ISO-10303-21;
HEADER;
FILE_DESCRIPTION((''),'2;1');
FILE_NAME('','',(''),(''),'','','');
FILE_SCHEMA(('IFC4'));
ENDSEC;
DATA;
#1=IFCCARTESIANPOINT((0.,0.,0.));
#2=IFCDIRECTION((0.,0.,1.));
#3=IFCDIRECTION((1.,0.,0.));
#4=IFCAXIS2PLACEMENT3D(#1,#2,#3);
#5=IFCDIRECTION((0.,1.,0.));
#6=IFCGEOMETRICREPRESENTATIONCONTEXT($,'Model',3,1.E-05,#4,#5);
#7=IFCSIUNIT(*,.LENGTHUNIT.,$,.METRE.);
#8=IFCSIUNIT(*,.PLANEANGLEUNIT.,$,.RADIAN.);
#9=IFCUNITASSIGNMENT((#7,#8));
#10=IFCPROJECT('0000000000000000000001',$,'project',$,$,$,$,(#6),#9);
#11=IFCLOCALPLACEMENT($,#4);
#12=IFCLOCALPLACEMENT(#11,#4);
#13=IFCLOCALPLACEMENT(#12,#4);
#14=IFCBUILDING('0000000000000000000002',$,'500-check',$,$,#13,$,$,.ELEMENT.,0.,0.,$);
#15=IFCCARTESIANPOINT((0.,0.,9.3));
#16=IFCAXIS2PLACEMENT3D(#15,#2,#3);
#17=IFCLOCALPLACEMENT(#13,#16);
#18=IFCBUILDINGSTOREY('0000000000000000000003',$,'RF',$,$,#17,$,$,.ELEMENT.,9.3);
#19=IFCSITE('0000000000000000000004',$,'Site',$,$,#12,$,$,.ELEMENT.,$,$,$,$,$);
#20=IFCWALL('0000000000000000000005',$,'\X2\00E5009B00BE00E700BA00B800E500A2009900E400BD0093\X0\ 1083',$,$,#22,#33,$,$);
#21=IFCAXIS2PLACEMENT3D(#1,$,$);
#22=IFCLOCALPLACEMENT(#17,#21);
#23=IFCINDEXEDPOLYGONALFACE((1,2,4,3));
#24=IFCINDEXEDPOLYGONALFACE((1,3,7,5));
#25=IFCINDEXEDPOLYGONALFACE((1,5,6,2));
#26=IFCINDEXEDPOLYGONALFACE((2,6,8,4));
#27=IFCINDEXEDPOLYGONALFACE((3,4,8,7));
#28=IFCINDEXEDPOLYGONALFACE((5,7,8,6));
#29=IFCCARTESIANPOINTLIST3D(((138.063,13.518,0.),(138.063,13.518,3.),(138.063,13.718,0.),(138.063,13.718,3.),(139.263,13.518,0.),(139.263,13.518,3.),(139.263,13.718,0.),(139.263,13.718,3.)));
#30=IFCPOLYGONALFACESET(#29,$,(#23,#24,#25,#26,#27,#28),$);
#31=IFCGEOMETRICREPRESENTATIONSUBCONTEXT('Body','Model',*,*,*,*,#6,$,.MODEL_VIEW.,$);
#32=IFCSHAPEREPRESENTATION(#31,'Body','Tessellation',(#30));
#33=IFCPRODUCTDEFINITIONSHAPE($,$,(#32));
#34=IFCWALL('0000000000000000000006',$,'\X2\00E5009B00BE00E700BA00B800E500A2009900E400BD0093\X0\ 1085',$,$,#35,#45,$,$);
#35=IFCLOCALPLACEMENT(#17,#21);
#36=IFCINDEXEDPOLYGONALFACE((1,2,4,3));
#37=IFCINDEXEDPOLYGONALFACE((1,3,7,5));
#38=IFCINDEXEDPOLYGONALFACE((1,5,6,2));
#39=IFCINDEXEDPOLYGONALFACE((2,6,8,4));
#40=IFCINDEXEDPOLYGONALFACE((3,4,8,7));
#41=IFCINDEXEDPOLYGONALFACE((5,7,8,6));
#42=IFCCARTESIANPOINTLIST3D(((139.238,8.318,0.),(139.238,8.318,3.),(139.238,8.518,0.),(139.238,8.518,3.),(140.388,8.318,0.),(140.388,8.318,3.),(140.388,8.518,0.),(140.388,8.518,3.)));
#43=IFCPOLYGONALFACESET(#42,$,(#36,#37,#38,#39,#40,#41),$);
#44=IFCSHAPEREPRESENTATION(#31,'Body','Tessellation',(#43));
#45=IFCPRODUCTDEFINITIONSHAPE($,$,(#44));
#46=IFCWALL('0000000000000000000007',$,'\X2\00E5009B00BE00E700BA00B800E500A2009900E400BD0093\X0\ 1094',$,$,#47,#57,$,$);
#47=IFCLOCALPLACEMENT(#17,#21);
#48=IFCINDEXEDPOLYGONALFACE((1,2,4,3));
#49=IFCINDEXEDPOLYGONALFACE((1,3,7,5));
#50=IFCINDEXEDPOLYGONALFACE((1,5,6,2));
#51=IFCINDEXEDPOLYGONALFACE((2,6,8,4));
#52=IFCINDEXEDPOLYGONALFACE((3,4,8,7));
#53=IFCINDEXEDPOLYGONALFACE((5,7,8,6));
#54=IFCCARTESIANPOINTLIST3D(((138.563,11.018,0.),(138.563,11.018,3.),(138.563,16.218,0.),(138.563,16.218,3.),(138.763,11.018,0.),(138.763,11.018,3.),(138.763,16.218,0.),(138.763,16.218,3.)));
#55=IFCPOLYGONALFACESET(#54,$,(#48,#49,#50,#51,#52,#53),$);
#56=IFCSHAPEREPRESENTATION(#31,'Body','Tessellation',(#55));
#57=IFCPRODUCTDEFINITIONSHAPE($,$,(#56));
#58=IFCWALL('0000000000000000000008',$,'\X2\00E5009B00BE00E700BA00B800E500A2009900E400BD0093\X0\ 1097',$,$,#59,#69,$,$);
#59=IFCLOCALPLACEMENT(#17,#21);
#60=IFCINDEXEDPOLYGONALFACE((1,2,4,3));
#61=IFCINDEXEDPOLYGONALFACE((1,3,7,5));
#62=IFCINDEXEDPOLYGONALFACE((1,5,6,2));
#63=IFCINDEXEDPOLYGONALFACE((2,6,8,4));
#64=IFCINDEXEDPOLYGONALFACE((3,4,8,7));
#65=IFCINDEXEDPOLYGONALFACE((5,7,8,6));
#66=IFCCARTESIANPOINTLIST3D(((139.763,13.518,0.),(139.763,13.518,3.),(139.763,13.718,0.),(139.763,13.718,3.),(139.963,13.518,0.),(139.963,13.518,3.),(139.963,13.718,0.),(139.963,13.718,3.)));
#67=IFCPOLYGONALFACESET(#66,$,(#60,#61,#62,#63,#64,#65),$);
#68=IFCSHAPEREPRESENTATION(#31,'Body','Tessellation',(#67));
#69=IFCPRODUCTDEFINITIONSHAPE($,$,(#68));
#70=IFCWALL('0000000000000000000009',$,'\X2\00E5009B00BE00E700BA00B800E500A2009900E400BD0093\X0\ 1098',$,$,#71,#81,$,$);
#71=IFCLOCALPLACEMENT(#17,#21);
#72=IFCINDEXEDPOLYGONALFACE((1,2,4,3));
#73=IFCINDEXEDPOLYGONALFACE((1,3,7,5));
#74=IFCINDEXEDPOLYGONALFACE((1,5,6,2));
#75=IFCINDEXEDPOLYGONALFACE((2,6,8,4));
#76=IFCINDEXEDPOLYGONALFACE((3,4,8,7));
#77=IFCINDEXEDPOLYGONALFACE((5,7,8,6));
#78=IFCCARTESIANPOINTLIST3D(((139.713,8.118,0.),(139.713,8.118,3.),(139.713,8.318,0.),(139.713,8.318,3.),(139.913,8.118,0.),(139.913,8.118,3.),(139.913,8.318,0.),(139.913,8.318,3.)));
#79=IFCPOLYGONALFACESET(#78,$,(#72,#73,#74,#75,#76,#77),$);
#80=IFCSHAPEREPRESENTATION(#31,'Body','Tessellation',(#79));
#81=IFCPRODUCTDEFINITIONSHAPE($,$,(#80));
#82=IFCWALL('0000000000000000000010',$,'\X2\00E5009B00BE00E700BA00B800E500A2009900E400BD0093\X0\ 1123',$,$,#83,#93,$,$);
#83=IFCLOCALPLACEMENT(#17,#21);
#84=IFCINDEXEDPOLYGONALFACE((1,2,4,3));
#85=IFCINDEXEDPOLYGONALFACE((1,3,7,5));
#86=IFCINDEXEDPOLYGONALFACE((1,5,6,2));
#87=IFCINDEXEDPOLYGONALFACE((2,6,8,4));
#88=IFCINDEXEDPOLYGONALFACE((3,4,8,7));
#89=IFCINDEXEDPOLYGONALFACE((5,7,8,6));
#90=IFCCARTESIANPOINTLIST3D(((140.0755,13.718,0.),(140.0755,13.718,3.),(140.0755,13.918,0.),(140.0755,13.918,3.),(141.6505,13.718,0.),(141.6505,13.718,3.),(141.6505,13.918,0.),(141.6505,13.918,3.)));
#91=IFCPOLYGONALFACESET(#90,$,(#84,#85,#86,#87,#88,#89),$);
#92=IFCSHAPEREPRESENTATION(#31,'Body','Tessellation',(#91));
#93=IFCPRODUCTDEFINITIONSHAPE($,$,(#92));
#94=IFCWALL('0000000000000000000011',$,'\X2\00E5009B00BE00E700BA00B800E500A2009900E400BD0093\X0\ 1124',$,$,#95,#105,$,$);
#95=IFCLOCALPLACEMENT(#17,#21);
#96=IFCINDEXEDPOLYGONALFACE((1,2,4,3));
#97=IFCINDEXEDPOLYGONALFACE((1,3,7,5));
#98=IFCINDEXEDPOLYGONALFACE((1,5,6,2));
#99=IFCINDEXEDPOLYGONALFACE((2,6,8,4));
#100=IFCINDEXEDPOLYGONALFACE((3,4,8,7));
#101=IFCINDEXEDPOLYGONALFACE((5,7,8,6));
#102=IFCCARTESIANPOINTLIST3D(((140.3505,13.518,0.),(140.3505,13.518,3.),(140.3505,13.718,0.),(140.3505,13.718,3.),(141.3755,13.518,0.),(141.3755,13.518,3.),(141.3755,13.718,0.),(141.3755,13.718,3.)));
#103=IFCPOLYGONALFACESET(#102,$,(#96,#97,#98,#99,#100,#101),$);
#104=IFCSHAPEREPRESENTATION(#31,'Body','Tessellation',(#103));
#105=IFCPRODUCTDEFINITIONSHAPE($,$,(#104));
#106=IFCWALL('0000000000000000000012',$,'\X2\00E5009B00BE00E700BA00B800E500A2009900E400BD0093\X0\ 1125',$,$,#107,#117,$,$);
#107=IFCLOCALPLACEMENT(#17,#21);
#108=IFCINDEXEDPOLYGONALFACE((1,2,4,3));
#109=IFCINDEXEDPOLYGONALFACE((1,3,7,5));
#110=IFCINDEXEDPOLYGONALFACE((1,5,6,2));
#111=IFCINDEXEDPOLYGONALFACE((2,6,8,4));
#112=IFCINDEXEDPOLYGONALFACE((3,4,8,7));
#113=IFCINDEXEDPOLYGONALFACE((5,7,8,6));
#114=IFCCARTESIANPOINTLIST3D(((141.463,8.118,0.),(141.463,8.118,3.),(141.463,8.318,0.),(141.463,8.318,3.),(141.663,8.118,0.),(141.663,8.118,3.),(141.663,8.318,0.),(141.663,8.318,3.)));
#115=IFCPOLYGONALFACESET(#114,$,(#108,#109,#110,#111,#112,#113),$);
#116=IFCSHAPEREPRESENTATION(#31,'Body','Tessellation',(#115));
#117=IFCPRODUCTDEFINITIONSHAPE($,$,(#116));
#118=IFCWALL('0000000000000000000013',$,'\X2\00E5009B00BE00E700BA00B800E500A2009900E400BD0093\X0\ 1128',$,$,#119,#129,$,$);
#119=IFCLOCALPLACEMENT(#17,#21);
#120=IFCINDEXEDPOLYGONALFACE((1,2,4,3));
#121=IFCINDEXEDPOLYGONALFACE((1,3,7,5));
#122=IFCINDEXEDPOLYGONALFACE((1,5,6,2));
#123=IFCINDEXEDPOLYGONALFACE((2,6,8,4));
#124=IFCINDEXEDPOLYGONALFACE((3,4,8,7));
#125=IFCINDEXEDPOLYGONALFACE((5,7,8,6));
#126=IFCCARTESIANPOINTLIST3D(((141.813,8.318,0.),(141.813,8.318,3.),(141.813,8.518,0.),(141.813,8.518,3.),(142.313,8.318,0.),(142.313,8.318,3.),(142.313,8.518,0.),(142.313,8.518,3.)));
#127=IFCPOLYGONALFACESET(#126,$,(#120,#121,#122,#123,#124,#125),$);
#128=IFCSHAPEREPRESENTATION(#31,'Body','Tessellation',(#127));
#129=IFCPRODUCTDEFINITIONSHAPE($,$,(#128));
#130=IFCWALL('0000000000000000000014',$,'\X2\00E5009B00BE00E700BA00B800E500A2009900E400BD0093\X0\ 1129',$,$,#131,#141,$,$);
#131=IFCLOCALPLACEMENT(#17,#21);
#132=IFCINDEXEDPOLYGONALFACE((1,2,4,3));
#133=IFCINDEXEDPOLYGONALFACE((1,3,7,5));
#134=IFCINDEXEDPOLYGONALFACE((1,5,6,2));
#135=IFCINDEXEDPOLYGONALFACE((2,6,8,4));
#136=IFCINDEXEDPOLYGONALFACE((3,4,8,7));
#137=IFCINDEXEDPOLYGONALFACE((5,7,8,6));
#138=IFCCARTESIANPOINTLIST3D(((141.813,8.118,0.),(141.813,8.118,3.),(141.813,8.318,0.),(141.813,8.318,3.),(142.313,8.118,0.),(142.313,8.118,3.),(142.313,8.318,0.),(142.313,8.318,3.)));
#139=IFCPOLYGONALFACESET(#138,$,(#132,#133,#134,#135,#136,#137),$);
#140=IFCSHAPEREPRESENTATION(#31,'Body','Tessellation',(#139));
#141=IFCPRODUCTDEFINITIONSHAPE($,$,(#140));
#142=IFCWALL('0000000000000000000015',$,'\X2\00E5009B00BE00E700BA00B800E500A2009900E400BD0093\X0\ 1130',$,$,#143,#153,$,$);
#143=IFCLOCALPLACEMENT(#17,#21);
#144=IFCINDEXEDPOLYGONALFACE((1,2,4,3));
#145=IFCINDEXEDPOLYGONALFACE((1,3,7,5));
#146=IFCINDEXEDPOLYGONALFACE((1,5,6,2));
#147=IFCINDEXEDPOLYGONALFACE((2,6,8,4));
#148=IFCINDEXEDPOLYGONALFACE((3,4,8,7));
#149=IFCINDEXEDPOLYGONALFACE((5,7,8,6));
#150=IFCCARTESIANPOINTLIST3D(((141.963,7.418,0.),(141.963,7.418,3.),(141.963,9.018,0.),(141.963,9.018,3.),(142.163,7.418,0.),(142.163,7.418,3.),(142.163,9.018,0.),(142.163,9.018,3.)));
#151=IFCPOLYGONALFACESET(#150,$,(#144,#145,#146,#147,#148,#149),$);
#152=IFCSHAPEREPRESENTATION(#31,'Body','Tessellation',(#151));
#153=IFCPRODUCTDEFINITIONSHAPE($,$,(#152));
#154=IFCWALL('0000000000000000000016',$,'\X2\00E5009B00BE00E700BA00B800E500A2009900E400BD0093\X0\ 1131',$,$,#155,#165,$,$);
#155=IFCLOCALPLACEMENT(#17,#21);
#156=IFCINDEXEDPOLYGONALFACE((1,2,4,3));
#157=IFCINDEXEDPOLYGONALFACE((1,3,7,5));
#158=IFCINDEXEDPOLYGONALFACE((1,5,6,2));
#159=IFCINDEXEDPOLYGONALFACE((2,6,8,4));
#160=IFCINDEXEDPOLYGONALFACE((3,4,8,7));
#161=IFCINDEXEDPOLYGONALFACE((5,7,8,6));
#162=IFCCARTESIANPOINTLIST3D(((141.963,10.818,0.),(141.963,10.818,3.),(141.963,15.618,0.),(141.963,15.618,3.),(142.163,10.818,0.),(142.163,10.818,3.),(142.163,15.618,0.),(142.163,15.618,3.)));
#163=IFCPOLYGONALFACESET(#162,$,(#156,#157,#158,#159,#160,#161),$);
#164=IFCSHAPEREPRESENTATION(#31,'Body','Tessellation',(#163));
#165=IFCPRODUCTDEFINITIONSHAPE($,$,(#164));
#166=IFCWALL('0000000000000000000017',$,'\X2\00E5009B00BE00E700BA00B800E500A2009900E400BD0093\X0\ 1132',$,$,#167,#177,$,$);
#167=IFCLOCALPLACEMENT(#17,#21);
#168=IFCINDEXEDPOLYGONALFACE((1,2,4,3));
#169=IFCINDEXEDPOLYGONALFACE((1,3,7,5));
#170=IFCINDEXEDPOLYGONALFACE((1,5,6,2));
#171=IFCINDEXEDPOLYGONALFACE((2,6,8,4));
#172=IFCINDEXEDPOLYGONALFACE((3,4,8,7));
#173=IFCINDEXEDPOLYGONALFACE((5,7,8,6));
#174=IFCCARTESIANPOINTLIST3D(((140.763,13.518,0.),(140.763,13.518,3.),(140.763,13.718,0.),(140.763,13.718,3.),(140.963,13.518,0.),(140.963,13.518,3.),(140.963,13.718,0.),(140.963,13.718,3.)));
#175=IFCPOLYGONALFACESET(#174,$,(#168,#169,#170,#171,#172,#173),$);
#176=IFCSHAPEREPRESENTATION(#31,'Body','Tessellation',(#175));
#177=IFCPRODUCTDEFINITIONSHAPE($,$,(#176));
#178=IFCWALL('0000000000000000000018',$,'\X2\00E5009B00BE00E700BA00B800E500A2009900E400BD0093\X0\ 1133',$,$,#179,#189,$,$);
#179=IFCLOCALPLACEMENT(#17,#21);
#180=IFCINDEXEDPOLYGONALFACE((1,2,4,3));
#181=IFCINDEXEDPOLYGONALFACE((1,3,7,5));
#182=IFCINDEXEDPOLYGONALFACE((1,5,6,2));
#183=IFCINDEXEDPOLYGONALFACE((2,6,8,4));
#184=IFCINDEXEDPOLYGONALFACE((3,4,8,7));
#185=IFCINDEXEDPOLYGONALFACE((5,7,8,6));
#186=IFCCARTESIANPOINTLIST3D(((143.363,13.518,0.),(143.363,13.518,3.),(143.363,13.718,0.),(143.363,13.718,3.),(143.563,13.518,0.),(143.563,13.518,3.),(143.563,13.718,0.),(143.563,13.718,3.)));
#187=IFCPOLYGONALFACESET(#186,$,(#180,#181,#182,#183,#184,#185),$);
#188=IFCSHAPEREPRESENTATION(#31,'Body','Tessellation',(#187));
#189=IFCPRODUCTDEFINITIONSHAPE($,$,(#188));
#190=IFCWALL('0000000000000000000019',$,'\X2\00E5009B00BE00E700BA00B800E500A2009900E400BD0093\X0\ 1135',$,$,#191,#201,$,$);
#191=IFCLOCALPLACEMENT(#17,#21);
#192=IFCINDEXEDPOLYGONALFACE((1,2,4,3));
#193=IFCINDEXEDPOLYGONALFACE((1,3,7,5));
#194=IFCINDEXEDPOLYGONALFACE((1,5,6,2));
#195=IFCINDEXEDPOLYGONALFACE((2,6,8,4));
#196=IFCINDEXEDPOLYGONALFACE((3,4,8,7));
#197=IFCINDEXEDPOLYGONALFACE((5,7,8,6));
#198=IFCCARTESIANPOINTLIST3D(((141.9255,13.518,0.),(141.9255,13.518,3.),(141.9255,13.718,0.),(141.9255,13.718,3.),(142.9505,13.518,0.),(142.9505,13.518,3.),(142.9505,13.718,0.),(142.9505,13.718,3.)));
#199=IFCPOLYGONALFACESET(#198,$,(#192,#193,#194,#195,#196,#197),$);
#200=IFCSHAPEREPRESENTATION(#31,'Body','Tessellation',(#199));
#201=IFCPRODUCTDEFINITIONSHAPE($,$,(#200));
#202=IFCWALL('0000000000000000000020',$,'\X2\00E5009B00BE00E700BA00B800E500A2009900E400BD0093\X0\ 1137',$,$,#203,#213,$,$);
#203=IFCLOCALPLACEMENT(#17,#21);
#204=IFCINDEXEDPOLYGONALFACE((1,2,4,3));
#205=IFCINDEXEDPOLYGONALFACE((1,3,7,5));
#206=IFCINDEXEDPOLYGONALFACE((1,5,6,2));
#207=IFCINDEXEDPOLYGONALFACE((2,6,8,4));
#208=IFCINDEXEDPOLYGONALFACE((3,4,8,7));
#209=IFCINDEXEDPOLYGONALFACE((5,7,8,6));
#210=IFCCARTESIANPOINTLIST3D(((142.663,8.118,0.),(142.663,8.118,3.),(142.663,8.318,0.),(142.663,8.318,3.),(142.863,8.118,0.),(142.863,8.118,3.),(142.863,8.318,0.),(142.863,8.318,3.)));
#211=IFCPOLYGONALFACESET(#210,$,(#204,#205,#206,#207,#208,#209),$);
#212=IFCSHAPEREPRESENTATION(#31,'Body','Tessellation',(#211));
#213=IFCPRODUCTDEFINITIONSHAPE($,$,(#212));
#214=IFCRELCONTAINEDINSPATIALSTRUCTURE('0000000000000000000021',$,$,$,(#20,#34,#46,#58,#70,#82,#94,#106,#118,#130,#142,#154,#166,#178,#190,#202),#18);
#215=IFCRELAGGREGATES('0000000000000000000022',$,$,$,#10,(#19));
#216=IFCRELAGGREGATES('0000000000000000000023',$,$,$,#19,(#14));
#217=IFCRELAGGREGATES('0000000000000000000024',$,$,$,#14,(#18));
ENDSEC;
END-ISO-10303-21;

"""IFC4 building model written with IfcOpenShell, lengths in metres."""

from ifc_helpers import new_model, si_unit, direction, frame, frame_2d, origin_with_axes, place, context, subcontext, project, spatial, rectangle, extrude, element, save


model = new_model("IFC4")

# Units and contexts
model_context = context("Model", 3, precision=1e-05, world=origin_with_axes(), true_north=direction((0.0, 1.0, 0.0)))
body_context = subcontext(model_context, "Body", "Model", "MODEL_VIEW")
ifc_project = project(units=[si_unit("LENGTHUNIT", "METRE"), si_unit("PLANEANGLEUNIT", "RADIAN")], contexts=[model_context])

# Site, building, storey
placement = place(None, origin_with_axes())
site_placement = place(placement, origin_with_axes())
site = spatial("IfcSite", under=ifc_project, at=site_placement, Name="Site", CompositionType="ELEMENT")
building_placement = place(site_placement, origin_with_axes())
building = spatial("IfcBuilding", under=site, at=building_placement, Name="500-check", CompositionType="ELEMENT", ElevationOfRefHeight=0.0, ElevationOfTerrain=0.0)
storey_placement = place(building_placement, frame((0.0, 0.0, 9.3), z_axis=(0.0, 0.0, 1.0), x_axis=(1.0, 0.0, 0.0)))
storey = spatial("IfcBuildingStorey", under=building, at=storey_placement, Name="RF", CompositionType="ELEMENT", Elevation=9.3)

# Walls
wall_1_placement = place(storey_placement, frame((138.663, 13.618, 0.0), z_axis=(0.0, 0.0, 1.0), x_axis=(1.0, 0.0, 0.0)))
element("IfcWall", 1, at=wall_1_placement, inside=storey, Name="å\u009b¾çº¸å¢\u0099ä½\u0093 1083", context=body_context, shape_type="SweptSolid", body=[
    extrude(rectangle(XDim=1.2, YDim=0.2, at=frame_2d((0.0, 0.0), x_axis=(1.0, 0.0, 0.0))), frame((0.0, 0.0, 0.0), z_axis=(0.0, 0.0, 1.0)), (0.0, 0.0, 1.0), 3.0),
])
wall_2_placement = place(storey_placement, frame((139.813, 8.418, 0.0), z_axis=(0.0, 0.0, 1.0), x_axis=(-1.0, 0.0, 0.0)))
element("IfcWall", 2, at=wall_2_placement, inside=storey, Name="å\u009b¾çº¸å¢\u0099ä½\u0093 1085", context=body_context, shape_type="SweptSolid", body=[
    extrude(rectangle(XDim=1.15, YDim=0.2, at=frame_2d((0.0, 0.0), x_axis=(1.0, 0.0, 0.0))), frame((0.0, 0.0, 0.0), z_axis=(0.0, 0.0, 1.0)), (0.0, 0.0, 1.0), 3.0),
])
wall_3_placement = place(storey_placement, frame((138.663, 13.618, 0.0), z_axis=(0.0, 0.0, 1.0), x_axis=(0.0, -1.0, 0.0)))
element("IfcWall", 3, at=wall_3_placement, inside=storey, Name="å\u009b¾çº¸å¢\u0099ä½\u0093 1094", context=body_context, shape_type="SweptSolid", body=[
    extrude(rectangle(XDim=5.2, YDim=0.2, at=frame_2d((0.0, 0.0), x_axis=(1.0, 0.0, 0.0))), frame((0.0, 0.0, 0.0), z_axis=(0.0, 0.0, 1.0)), (0.0, 0.0, 1.0), 3.0),
])
for number, where, z_axis, x_axis, name in (
    (4, (139.863, 13.618, 0.0), (0.0, 0.0, 1.0), (0.0, 1.0, 0.0), "å\u009b¾çº¸å¢\u0099ä½\u0093 1097"),
    (5, (139.813, 8.218, 0.0), (0.0, 0.0, 1.0), (0.0, 1.0, 0.0), "å\u009b¾çº¸å¢\u0099ä½\u0093 1098"),
):
    element("IfcWall", number, at=place(storey_placement, frame(where, z_axis=z_axis, x_axis=x_axis)), inside=storey, Name=name, context=body_context, shape_type="SweptSolid", body=[
        extrude(rectangle(XDim=0.2, YDim=0.2, at=frame_2d((0.0, 0.0), x_axis=(1.0, 0.0, 0.0))), frame((0.0, 0.0, 0.0), z_axis=(0.0, 0.0, 1.0)), (0.0, 0.0, 1.0), 3.0),
    ])
wall_4_placement = place(storey_placement, frame((140.863, 13.818, 0.0), z_axis=(0.0, 0.0, 1.0), x_axis=(1.0, 0.0, 0.0)))
element("IfcWall", 6, at=wall_4_placement, inside=storey, Name="å\u009b¾çº¸å¢\u0099ä½\u0093 1123", context=body_context, shape_type="SweptSolid", body=[
    extrude(rectangle(XDim=1.575, YDim=0.2, at=frame_2d((0.0, 0.0), x_axis=(1.0, 0.0, 0.0))), frame((0.0, 0.0, 0.0), z_axis=(0.0, 0.0, 1.0)), (0.0, 0.0, 1.0), 3.0),
])
wall_5_placement = place(storey_placement, frame((140.863, 13.618, 0.0), z_axis=(0.0, 0.0, 1.0), x_axis=(1.0, 0.0, 0.0)))
element("IfcWall", 7, at=wall_5_placement, inside=storey, Name="å\u009b¾çº¸å¢\u0099ä½\u0093 1124", context=body_context, shape_type="SweptSolid", body=[
    extrude(rectangle(XDim=1.025, YDim=0.2, at=frame_2d((0.0, 0.0), x_axis=(1.0, 0.0, 0.0))), frame((0.0, 0.0, 0.0), z_axis=(0.0, 0.0, 1.0)), (0.0, 0.0, 1.0), 3.0),
])
wall_6_placement = place(storey_placement, frame((141.563, 8.218, 0.0), z_axis=(0.0, 0.0, 1.0), x_axis=(0.0, 1.0, 0.0)))
element("IfcWall", 8, at=wall_6_placement, inside=storey, Name="å\u009b¾çº¸å¢\u0099ä½\u0093 1125", context=body_context, shape_type="SweptSolid", body=[
    extrude(rectangle(XDim=0.2, YDim=0.2, at=frame_2d((0.0, 0.0), x_axis=(1.0, 0.0, 0.0))), frame((0.0, 0.0, 0.0), z_axis=(0.0, 0.0, 1.0)), (0.0, 0.0, 1.0), 3.0),
])
for number, where, z_axis, x_axis, name in (
    (9, (142.063, 8.418, 0.0), (0.0, 0.0, 1.0), (-1.0, 0.0, 0.0), "å\u009b¾çº¸å¢\u0099ä½\u0093 1128"),
    (10, (142.063, 8.218, 0.0), (0.0, 0.0, 1.0), (-1.0, 0.0, 0.0), "å\u009b¾çº¸å¢\u0099ä½\u0093 1129"),
):
    element("IfcWall", number, at=place(storey_placement, frame(where, z_axis=z_axis, x_axis=x_axis)), inside=storey, Name=name, context=body_context, shape_type="SweptSolid", body=[
        extrude(rectangle(XDim=0.5, YDim=0.2, at=frame_2d((0.0, 0.0), x_axis=(1.0, 0.0, 0.0))), frame((0.0, 0.0, 0.0), z_axis=(0.0, 0.0, 1.0)), (0.0, 0.0, 1.0), 3.0),
    ])
wall_7_placement = place(storey_placement, frame((142.063, 8.218, 0.0), z_axis=(0.0, 0.0, 1.0), x_axis=(0.0, -1.0, 0.0)))
element("IfcWall", 11, at=wall_7_placement, inside=storey, Name="å\u009b¾çº¸å¢\u0099ä½\u0093 1130", context=body_context, shape_type="SweptSolid", body=[
    extrude(rectangle(XDim=1.6, YDim=0.2, at=frame_2d((0.0, 0.0), x_axis=(1.0, 0.0, 0.0))), frame((0.0, 0.0, 0.0), z_axis=(0.0, 0.0, 1.0)), (0.0, 0.0, 1.0), 3.0),
])
wall_8_placement = place(storey_placement, frame((142.063, 13.218, 0.0), z_axis=(0.0, 0.0, 1.0), x_axis=(0.0, -1.0, 0.0)))
element("IfcWall", 12, at=wall_8_placement, inside=storey, Name="å\u009b¾çº¸å¢\u0099ä½\u0093 1131", context=body_context, shape_type="SweptSolid", body=[
    extrude(rectangle(XDim=4.8, YDim=0.2, at=frame_2d((0.0, 0.0), x_axis=(1.0, 0.0, 0.0))), frame((0.0, 0.0, 0.0), z_axis=(0.0, 0.0, 1.0)), (0.0, 0.0, 1.0), 3.0),
])
for number, where, z_axis, x_axis, name in (
    (13, (140.863, 13.618, 0.0), (0.0, 0.0, 1.0), (0.0, 1.0, 0.0), "å\u009b¾çº¸å¢\u0099ä½\u0093 1132"),
    (14, (143.463, 13.618, 0.0), (0.0, 0.0, 1.0), (0.0, 1.0, 0.0), "å\u009b¾çº¸å¢\u0099ä½\u0093 1133"),
):
    element("IfcWall", number, at=place(storey_placement, frame(where, z_axis=z_axis, x_axis=x_axis)), inside=storey, Name=name, context=body_context, shape_type="SweptSolid", body=[
        extrude(rectangle(XDim=0.2, YDim=0.2, at=frame_2d((0.0, 0.0), x_axis=(1.0, 0.0, 0.0))), frame((0.0, 0.0, 0.0), z_axis=(0.0, 0.0, 1.0)), (0.0, 0.0, 1.0), 3.0),
    ])
wall_9_placement = place(storey_placement, frame((142.438, 13.618, 0.0), z_axis=(0.0, 0.0, 1.0), x_axis=(1.0, 0.0, 0.0)))
element("IfcWall", 15, at=wall_9_placement, inside=storey, Name="å\u009b¾çº¸å¢\u0099ä½\u0093 1135", context=body_context, shape_type="SweptSolid", body=[
    extrude(rectangle(XDim=1.025, YDim=0.2, at=frame_2d((0.0, 0.0), x_axis=(1.0, 0.0, 0.0))), frame((0.0, 0.0, 0.0), z_axis=(0.0, 0.0, 1.0)), (0.0, 0.0, 1.0), 3.0),
])
wall_10_placement = place(storey_placement, frame((142.763, 8.218, 0.0), z_axis=(0.0, 0.0, 1.0), x_axis=(0.0, 1.0, 0.0)))
element("IfcWall", 16, at=wall_10_placement, inside=storey, Name="å\u009b¾çº¸å¢\u0099ä½\u0093 1137", context=body_context, shape_type="SweptSolid", body=[
    extrude(rectangle(XDim=0.2, YDim=0.2, at=frame_2d((0.0, 0.0), x_axis=(1.0, 0.0, 0.0))), frame((0.0, 0.0, 0.0), z_axis=(0.0, 0.0, 1.0)), (0.0, 0.0, 1.0), 3.0),
])

save(model, "model.ifc")
